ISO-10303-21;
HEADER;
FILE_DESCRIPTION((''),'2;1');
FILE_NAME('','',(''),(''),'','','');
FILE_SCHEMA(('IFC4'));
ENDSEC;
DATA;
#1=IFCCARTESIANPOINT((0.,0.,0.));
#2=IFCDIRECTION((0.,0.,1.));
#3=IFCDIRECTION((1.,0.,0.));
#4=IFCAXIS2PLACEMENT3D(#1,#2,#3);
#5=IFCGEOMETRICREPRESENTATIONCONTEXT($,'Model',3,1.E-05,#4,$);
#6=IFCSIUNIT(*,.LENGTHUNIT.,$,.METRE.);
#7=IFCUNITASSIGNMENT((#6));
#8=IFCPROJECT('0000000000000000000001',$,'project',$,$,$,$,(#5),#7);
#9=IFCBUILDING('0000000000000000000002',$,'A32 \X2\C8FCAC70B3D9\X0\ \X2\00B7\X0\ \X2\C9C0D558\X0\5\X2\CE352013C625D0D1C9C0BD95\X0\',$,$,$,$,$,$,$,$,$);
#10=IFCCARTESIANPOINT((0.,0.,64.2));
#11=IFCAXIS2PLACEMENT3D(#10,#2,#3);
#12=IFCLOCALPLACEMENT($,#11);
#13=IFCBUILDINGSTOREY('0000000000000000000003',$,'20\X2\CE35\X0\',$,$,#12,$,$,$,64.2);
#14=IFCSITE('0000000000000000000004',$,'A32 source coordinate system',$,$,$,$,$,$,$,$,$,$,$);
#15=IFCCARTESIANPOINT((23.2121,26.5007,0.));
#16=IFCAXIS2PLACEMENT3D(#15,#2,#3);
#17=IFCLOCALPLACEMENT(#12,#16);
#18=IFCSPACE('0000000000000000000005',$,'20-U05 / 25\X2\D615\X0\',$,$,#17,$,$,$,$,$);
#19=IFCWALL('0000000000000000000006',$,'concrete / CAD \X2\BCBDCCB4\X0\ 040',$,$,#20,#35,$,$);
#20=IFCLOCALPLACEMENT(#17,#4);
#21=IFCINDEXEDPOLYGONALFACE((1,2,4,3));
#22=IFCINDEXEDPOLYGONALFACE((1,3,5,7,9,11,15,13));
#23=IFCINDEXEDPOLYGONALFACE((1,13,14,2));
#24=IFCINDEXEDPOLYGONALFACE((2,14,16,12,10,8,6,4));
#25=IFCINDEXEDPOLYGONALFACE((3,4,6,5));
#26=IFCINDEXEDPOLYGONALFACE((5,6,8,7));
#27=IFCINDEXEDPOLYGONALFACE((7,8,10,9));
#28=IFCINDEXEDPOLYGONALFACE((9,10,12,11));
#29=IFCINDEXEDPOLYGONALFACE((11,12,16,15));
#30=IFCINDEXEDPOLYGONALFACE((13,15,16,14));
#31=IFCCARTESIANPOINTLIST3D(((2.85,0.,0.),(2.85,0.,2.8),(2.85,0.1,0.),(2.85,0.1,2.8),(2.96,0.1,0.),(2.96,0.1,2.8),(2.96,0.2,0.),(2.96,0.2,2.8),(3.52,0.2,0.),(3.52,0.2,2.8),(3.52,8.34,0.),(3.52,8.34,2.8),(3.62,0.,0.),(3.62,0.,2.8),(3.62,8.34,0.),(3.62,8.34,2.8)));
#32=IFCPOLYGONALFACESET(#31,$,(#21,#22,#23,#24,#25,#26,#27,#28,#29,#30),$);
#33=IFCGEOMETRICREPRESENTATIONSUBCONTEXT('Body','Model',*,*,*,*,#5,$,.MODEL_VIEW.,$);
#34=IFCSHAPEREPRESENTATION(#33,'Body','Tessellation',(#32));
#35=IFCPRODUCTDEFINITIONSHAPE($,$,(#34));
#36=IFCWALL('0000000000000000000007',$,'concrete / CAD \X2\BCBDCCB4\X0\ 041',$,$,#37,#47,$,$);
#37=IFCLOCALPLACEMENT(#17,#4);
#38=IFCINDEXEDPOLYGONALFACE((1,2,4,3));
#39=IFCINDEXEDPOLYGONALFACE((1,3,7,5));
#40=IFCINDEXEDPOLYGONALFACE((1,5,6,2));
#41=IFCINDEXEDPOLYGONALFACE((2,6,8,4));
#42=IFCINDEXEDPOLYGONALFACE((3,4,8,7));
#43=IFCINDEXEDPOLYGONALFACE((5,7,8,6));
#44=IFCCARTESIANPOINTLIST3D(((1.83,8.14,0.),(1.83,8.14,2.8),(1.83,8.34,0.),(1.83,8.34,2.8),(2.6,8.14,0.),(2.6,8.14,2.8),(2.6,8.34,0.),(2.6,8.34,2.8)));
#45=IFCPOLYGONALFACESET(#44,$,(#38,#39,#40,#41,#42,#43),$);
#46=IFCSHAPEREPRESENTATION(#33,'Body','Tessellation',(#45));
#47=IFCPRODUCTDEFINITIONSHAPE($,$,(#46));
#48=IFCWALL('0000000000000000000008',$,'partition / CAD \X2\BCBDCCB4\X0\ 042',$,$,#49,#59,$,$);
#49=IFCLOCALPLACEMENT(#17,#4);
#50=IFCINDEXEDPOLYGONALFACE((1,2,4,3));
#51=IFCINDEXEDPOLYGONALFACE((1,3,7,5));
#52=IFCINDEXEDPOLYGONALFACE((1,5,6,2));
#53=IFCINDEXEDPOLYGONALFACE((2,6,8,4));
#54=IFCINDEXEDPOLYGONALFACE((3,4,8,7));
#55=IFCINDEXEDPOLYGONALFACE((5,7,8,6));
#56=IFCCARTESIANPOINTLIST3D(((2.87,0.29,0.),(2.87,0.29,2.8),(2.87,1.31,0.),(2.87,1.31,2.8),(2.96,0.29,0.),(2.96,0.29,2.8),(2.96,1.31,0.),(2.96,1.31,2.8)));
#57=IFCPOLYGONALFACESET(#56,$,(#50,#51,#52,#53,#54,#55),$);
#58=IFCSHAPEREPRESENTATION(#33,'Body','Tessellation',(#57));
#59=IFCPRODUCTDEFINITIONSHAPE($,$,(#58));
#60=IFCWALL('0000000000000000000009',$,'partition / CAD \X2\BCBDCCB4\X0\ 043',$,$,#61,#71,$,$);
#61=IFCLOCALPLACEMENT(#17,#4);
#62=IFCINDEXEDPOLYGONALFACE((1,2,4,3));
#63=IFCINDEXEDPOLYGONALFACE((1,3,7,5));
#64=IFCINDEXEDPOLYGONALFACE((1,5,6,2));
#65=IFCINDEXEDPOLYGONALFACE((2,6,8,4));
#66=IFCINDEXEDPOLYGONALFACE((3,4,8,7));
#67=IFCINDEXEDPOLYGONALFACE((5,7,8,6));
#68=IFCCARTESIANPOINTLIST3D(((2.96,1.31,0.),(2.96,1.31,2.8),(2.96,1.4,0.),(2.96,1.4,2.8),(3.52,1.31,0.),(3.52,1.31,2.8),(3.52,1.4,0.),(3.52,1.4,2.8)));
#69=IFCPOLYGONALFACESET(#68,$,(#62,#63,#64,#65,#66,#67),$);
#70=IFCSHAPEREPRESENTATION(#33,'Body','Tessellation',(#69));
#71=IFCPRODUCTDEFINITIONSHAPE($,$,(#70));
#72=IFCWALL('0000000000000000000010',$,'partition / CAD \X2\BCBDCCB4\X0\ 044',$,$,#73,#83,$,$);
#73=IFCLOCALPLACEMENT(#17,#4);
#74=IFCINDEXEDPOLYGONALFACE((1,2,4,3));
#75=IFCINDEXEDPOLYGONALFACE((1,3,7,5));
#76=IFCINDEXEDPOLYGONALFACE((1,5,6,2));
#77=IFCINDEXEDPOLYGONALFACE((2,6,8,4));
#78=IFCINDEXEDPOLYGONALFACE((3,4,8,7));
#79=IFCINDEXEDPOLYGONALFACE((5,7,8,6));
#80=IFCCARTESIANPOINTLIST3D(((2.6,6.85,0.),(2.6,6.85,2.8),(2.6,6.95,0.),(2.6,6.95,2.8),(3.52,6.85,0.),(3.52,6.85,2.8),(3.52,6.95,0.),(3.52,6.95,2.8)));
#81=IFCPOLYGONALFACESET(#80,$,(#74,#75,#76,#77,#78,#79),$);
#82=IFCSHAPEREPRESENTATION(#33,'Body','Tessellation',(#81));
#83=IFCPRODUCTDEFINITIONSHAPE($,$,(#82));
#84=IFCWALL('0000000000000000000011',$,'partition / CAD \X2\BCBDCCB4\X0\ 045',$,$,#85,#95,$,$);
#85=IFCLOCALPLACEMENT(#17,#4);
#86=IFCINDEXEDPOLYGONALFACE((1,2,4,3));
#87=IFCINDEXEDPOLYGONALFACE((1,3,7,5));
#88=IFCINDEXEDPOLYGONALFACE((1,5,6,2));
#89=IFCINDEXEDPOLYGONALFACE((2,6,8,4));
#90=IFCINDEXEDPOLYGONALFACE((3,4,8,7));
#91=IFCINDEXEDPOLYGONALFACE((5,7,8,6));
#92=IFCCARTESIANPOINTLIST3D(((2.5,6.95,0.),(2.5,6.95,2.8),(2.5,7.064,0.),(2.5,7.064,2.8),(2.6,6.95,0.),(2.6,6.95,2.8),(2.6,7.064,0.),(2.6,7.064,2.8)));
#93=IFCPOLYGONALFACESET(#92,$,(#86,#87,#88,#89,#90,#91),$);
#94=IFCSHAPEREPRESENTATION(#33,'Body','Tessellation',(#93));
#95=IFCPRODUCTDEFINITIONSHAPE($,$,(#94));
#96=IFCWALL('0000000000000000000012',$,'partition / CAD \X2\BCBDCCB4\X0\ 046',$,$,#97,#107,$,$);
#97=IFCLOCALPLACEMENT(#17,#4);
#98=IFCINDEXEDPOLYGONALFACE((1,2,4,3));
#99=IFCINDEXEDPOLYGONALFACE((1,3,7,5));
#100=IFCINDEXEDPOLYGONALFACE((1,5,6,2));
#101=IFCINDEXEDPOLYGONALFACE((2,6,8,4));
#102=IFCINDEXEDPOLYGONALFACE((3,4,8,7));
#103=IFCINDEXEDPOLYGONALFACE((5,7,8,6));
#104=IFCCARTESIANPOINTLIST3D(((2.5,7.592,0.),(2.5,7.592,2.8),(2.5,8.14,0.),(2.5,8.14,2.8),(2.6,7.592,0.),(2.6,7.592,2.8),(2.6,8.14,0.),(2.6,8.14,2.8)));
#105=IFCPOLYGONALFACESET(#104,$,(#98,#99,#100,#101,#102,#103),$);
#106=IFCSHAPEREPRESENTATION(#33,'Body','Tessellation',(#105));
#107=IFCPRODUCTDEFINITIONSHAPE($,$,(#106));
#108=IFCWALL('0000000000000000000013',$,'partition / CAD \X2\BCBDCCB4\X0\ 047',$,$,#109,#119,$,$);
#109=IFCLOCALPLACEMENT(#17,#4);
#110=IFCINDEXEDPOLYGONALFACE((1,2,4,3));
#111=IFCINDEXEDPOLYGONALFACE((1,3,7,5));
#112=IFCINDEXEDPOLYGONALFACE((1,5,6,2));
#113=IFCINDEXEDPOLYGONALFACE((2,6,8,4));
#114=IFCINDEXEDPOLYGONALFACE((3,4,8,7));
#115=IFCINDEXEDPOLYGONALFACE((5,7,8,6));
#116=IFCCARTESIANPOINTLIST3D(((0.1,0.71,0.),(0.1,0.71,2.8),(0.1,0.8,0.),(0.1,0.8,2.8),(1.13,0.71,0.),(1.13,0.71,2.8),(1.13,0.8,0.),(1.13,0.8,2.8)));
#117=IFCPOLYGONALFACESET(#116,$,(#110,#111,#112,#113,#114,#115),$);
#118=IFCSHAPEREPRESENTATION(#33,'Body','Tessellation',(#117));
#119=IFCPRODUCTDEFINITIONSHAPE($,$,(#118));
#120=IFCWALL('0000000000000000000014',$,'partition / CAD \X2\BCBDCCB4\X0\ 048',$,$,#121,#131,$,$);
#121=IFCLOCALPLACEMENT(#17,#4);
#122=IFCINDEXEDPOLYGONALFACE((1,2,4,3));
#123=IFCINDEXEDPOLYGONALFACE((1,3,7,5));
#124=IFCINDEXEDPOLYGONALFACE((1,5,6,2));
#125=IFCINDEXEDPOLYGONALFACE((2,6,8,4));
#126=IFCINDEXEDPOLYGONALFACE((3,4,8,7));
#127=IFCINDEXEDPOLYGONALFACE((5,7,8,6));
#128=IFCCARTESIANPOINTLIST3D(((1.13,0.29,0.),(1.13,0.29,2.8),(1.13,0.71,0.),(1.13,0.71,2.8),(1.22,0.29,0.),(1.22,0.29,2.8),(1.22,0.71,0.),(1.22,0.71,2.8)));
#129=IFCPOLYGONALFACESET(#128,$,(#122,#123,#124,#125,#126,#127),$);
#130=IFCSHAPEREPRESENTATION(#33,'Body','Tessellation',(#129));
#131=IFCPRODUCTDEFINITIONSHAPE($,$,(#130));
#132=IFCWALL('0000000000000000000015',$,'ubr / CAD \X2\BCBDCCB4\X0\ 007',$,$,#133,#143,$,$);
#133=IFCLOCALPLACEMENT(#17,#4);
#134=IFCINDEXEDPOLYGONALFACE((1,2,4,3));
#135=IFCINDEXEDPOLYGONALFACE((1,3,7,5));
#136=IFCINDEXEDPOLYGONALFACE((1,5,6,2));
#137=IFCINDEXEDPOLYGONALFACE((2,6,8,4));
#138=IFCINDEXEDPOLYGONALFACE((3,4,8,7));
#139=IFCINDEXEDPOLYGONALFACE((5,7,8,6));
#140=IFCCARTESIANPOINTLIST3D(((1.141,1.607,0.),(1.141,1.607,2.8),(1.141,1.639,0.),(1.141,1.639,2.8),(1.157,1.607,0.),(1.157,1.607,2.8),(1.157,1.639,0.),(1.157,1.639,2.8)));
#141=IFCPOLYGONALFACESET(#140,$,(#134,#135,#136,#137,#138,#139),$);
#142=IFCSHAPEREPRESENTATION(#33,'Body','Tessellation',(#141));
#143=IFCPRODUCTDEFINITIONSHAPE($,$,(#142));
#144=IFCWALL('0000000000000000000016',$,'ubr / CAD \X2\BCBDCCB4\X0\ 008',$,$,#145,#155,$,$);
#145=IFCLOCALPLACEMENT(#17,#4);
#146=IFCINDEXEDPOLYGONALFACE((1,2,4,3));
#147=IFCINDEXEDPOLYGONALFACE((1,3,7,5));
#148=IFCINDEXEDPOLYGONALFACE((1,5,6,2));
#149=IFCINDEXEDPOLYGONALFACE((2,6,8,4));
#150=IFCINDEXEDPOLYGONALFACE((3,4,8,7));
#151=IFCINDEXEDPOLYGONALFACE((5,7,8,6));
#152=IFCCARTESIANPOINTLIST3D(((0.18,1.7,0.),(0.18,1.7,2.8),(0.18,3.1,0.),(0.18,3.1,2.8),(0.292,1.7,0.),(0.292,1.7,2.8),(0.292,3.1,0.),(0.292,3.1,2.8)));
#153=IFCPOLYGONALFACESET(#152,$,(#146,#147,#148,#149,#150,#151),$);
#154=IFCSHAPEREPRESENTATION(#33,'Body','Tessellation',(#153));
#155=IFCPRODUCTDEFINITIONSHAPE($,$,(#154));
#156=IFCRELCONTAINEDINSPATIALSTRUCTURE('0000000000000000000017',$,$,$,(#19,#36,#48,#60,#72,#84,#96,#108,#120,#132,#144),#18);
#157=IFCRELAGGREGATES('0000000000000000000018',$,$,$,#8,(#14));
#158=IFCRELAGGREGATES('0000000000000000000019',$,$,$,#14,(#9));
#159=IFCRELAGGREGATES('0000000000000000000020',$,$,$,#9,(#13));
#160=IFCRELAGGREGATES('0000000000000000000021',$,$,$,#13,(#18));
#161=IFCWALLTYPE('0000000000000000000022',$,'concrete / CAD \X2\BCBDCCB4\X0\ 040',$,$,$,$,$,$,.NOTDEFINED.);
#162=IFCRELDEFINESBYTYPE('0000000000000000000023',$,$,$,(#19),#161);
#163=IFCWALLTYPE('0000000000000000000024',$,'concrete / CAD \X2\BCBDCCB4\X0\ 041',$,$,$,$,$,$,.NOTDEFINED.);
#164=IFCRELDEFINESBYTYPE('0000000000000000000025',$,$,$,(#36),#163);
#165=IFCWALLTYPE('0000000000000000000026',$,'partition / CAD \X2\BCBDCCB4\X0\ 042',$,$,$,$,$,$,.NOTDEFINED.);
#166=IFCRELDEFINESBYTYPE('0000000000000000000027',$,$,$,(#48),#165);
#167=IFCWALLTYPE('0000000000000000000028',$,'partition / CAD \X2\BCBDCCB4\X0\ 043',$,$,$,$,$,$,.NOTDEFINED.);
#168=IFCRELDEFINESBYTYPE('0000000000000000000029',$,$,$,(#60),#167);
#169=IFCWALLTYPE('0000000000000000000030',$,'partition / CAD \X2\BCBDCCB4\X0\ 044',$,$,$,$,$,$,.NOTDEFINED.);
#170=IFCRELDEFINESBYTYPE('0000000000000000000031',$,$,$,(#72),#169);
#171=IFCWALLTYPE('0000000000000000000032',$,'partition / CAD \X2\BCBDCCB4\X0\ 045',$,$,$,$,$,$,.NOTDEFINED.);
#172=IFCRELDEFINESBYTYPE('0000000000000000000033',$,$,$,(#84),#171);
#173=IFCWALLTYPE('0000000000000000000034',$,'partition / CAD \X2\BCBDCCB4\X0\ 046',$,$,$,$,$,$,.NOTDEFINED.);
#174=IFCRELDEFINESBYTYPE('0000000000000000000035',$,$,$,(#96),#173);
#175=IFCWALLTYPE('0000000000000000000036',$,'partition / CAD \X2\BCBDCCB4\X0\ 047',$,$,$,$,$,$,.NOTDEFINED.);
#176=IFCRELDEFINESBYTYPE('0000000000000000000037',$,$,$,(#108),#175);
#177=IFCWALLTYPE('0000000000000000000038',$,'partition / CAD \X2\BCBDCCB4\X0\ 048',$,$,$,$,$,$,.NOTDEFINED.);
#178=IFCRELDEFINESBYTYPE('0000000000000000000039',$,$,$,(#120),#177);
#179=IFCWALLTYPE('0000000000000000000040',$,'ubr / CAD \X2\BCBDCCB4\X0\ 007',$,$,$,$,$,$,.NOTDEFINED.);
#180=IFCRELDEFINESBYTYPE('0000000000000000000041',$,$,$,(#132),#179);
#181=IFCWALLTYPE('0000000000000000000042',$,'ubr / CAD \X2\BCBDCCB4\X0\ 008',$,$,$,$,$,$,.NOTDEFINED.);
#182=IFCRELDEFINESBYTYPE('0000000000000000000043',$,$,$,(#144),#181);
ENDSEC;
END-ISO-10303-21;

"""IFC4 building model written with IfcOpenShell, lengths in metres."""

from ifc_helpers import new_model, si_unit, frame, origin, origin_with_axes, place, context, subcontext, project, spatial, polyline, outline, extrude, source, transform, mapped, type_object, type_shapes, element, save


model = new_model("IFC4")

# Units and contexts
model_context = context("Model", 3, precision=1e-05, world=origin_with_axes())
body_context = subcontext(model_context, "Body", "Model", "MODEL_VIEW")
ifc_project = project(units=[si_unit("LENGTHUNIT", "METRE")], contexts=[model_context])

# Site, building, storey, space
site = spatial("IfcSite", under=ifc_project, Name="A32 source coordinate system")
building = spatial("IfcBuilding", under=site, Name="A32 주거동 · 지하5층–옥탑지붕")
storey_placement = place(None, frame((0.0, 0.0, 64.2), z_axis=(0.0, 0.0, 1.0), x_axis=(1.0, 0.0, 0.0)))
storey = spatial("IfcBuildingStorey", under=building, at=storey_placement, Name="20층", Elevation=64.2)
space_1_placement = place(storey_placement, frame((23.2121, 26.5007, 0.0), z_axis=(0.0, 0.0, 1.0), x_axis=(1.0, 0.0, 0.0)))
space_1 = spatial("IfcSpace", under=storey, at=space_1_placement, Name="20-U05 / 25형")

# Walls
wall_type_1 = type_object("IfcWallType", Name="concrete / CAD 벽체 040", PredefinedType="NOTDEFINED")
shared_shape_1 = source(origin(), body_context, "Body", "SweptSolid", [
    extrude(outline(polyline([(3.62, 8.34), (3.62, 0.0), (2.85, 0.0), (2.85, 0.1), (2.96, 0.1), (2.96, 0.2), (3.52, 0.2), (3.52, 8.34), (3.62, 8.34)])), origin(), (0.0, 0.0, 1.0), 2.8),
])
type_shapes(wall_type_1, [shared_shape_1])
wall_1_placement = place(space_1_placement, origin_with_axes())
element("IfcWall", 1, at=wall_1_placement, inside=space_1, type_object=wall_type_1, Name="concrete / CAD 벽체 040", context=body_context, shape_type="MappedRepresentation", body=[
    mapped(shared_shape_1, transform((0.0, 0.0, 0.0), scale=1.0)),
])
wall_type_2 = type_object("IfcWallType", Name="concrete / CAD 벽체 041", PredefinedType="NOTDEFINED")
shared_shape_2 = source(origin(), body_context, "Body", "SweptSolid", [
    extrude(outline(polyline([(2.6, 8.14), (1.83, 8.14), (1.83, 8.34), (2.6, 8.34), (2.6, 8.14)])), origin(), (0.0, 0.0, 1.0), 2.8),
])
type_shapes(wall_type_2, [shared_shape_2])
wall_2_placement = place(space_1_placement, origin_with_axes())
element("IfcWall", 2, at=wall_2_placement, inside=space_1, type_object=wall_type_2, Name="concrete / CAD 벽체 041", context=body_context, shape_type="MappedRepresentation", body=[
    mapped(shared_shape_2, transform((0.0, 0.0, 0.0), scale=1.0)),
])
wall_type_3 = type_object("IfcWallType", Name="partition / CAD 벽체 042", PredefinedType="NOTDEFINED")
shared_shape_3 = source(origin(), body_context, "Body", "SweptSolid", [
    extrude(outline(polyline([(2.87, 1.31), (2.96, 1.31), (2.96, 0.29), (2.87, 0.29), (2.87, 1.31)])), origin(), (0.0, 0.0, 1.0), 2.8),
])
type_shapes(wall_type_3, [shared_shape_3])
wall_3_placement = place(space_1_placement, origin_with_axes())
element("IfcWall", 3, at=wall_3_placement, inside=space_1, type_object=wall_type_3, Name="partition / CAD 벽체 042", context=body_context, shape_type="MappedRepresentation", body=[
    mapped(shared_shape_3, transform((0.0, 0.0, 0.0), scale=1.0)),
])
wall_type_4 = type_object("IfcWallType", Name="partition / CAD 벽체 043", PredefinedType="NOTDEFINED")
shared_shape_4 = source(origin(), body_context, "Body", "SweptSolid", [
    extrude(outline(polyline([(3.52, 1.4), (3.52, 1.31), (2.96, 1.31), (2.96, 1.4), (3.52, 1.4)])), origin(), (0.0, 0.0, 1.0), 2.8),
])
type_shapes(wall_type_4, [shared_shape_4])
wall_4_placement = place(space_1_placement, origin_with_axes())
element("IfcWall", 4, at=wall_4_placement, inside=space_1, type_object=wall_type_4, Name="partition / CAD 벽체 043", context=body_context, shape_type="MappedRepresentation", body=[
    mapped(shared_shape_4, transform((0.0, 0.0, 0.0), scale=1.0)),
])
wall_type_5 = type_object("IfcWallType", Name="partition / CAD 벽체 044", PredefinedType="NOTDEFINED")
shared_shape_5 = source(origin(), body_context, "Body", "SweptSolid", [
    extrude(outline(polyline([(3.52, 6.95), (3.52, 6.85), (2.6, 6.85), (2.6, 6.95), (3.52, 6.95)])), origin(), (0.0, 0.0, 1.0), 2.8),
])
type_shapes(wall_type_5, [shared_shape_5])
wall_5_placement = place(space_1_placement, origin_with_axes())
element("IfcWall", 5, at=wall_5_placement, inside=space_1, type_object=wall_type_5, Name="partition / CAD 벽체 044", context=body_context, shape_type="MappedRepresentation", body=[
    mapped(shared_shape_5, transform((0.0, 0.0, 0.0), scale=1.0)),
])
wall_type_6 = type_object("IfcWallType", Name="partition / CAD 벽체 045", PredefinedType="NOTDEFINED")
shared_shape_6 = source(origin(), body_context, "Body", "SweptSolid", [
    extrude(outline(polyline([(2.5, 7.064), (2.6, 7.064), (2.6, 6.95), (2.5, 6.95), (2.5, 7.064)])), origin(), (0.0, 0.0, 1.0), 2.8),
])
type_shapes(wall_type_6, [shared_shape_6])
wall_6_placement = place(space_1_placement, origin_with_axes())
element("IfcWall", 6, at=wall_6_placement, inside=space_1, type_object=wall_type_6, Name="partition / CAD 벽체 045", context=body_context, shape_type="MappedRepresentation", body=[
    mapped(shared_shape_6, transform((0.0, 0.0, 0.0), scale=1.0)),
])
wall_type_7 = type_object("IfcWallType", Name="partition / CAD 벽체 046", PredefinedType="NOTDEFINED")
shared_shape_7 = source(origin(), body_context, "Body", "SweptSolid", [
    extrude(outline(polyline([(2.6, 7.592), (2.5, 7.592), (2.5, 8.14), (2.6, 8.14), (2.6, 7.592)])), origin(), (0.0, 0.0, 1.0), 2.8),
])
type_shapes(wall_type_7, [shared_shape_7])
wall_7_placement = place(space_1_placement, origin_with_axes())
element("IfcWall", 7, at=wall_7_placement, inside=space_1, type_object=wall_type_7, Name="partition / CAD 벽체 046", context=body_context, shape_type="MappedRepresentation", body=[
    mapped(shared_shape_7, transform((0.0, 0.0, 0.0), scale=1.0)),
])
wall_type_8 = type_object("IfcWallType", Name="partition / CAD 벽체 047", PredefinedType="NOTDEFINED")
shared_shape_8 = source(origin(), body_context, "Body", "SweptSolid", [
    extrude(outline(polyline([(1.13, 0.71), (0.1, 0.71), (0.1, 0.8), (1.13, 0.8), (1.13, 0.71)])), origin(), (0.0, 0.0, 1.0), 2.8),
])
type_shapes(wall_type_8, [shared_shape_8])
wall_8_placement = place(space_1_placement, origin_with_axes())
element("IfcWall", 8, at=wall_8_placement, inside=space_1, type_object=wall_type_8, Name="partition / CAD 벽체 047", context=body_context, shape_type="MappedRepresentation", body=[
    mapped(shared_shape_8, transform((0.0, 0.0, 0.0), scale=1.0)),
])
wall_type_9 = type_object("IfcWallType", Name="partition / CAD 벽체 048", PredefinedType="NOTDEFINED")
shared_shape_9 = source(origin(), body_context, "Body", "SweptSolid", [
    extrude(outline(polyline([(1.22, 0.29), (1.13, 0.29), (1.13, 0.71), (1.22, 0.71), (1.22, 0.29)])), origin(), (0.0, 0.0, 1.0), 2.8),
])
type_shapes(wall_type_9, [shared_shape_9])
wall_9_placement = place(space_1_placement, origin_with_axes())
element("IfcWall", 9, at=wall_9_placement, inside=space_1, type_object=wall_type_9, Name="partition / CAD 벽체 048", context=body_context, shape_type="MappedRepresentation", body=[
    mapped(shared_shape_9, transform((0.0, 0.0, 0.0), scale=1.0)),
])
wall_type_10 = type_object("IfcWallType", Name="ubr / CAD 벽체 007", PredefinedType="NOTDEFINED")
shared_shape_10 = source(origin(), body_context, "Body", "SweptSolid", [
    extrude(outline(polyline([(1.157, 1.607), (1.141, 1.607), (1.141, 1.639), (1.157, 1.639), (1.157, 1.607)])), origin(), (0.0, 0.0, 1.0), 2.8),
])
type_shapes(wall_type_10, [shared_shape_10])
wall_10_placement = place(space_1_placement, origin_with_axes())
element("IfcWall", 10, at=wall_10_placement, inside=space_1, type_object=wall_type_10, Name="ubr / CAD 벽체 007", context=body_context, shape_type="MappedRepresentation", body=[
    mapped(shared_shape_10, transform((0.0, 0.0, 0.0), scale=1.0)),
])
wall_type_11 = type_object("IfcWallType", Name="ubr / CAD 벽체 008", PredefinedType="NOTDEFINED")
shared_shape_11 = source(origin(), body_context, "Body", "SweptSolid", [
    extrude(outline(polyline([(0.292, 1.7), (0.18, 1.7), (0.18, 3.1), (0.292, 3.1), (0.292, 1.7)])), origin(), (0.0, 0.0, 1.0), 2.8),
])
type_shapes(wall_type_11, [shared_shape_11])
wall_11_placement = place(space_1_placement, origin_with_axes())
element("IfcWall", 11, at=wall_11_placement, inside=space_1, type_object=wall_type_11, Name="ubr / CAD 벽체 008", context=body_context, shape_type="MappedRepresentation", body=[
    mapped(shared_shape_11, transform((0.0, 0.0, 0.0), scale=1.0)),
])

save(model, "model.ifc")
